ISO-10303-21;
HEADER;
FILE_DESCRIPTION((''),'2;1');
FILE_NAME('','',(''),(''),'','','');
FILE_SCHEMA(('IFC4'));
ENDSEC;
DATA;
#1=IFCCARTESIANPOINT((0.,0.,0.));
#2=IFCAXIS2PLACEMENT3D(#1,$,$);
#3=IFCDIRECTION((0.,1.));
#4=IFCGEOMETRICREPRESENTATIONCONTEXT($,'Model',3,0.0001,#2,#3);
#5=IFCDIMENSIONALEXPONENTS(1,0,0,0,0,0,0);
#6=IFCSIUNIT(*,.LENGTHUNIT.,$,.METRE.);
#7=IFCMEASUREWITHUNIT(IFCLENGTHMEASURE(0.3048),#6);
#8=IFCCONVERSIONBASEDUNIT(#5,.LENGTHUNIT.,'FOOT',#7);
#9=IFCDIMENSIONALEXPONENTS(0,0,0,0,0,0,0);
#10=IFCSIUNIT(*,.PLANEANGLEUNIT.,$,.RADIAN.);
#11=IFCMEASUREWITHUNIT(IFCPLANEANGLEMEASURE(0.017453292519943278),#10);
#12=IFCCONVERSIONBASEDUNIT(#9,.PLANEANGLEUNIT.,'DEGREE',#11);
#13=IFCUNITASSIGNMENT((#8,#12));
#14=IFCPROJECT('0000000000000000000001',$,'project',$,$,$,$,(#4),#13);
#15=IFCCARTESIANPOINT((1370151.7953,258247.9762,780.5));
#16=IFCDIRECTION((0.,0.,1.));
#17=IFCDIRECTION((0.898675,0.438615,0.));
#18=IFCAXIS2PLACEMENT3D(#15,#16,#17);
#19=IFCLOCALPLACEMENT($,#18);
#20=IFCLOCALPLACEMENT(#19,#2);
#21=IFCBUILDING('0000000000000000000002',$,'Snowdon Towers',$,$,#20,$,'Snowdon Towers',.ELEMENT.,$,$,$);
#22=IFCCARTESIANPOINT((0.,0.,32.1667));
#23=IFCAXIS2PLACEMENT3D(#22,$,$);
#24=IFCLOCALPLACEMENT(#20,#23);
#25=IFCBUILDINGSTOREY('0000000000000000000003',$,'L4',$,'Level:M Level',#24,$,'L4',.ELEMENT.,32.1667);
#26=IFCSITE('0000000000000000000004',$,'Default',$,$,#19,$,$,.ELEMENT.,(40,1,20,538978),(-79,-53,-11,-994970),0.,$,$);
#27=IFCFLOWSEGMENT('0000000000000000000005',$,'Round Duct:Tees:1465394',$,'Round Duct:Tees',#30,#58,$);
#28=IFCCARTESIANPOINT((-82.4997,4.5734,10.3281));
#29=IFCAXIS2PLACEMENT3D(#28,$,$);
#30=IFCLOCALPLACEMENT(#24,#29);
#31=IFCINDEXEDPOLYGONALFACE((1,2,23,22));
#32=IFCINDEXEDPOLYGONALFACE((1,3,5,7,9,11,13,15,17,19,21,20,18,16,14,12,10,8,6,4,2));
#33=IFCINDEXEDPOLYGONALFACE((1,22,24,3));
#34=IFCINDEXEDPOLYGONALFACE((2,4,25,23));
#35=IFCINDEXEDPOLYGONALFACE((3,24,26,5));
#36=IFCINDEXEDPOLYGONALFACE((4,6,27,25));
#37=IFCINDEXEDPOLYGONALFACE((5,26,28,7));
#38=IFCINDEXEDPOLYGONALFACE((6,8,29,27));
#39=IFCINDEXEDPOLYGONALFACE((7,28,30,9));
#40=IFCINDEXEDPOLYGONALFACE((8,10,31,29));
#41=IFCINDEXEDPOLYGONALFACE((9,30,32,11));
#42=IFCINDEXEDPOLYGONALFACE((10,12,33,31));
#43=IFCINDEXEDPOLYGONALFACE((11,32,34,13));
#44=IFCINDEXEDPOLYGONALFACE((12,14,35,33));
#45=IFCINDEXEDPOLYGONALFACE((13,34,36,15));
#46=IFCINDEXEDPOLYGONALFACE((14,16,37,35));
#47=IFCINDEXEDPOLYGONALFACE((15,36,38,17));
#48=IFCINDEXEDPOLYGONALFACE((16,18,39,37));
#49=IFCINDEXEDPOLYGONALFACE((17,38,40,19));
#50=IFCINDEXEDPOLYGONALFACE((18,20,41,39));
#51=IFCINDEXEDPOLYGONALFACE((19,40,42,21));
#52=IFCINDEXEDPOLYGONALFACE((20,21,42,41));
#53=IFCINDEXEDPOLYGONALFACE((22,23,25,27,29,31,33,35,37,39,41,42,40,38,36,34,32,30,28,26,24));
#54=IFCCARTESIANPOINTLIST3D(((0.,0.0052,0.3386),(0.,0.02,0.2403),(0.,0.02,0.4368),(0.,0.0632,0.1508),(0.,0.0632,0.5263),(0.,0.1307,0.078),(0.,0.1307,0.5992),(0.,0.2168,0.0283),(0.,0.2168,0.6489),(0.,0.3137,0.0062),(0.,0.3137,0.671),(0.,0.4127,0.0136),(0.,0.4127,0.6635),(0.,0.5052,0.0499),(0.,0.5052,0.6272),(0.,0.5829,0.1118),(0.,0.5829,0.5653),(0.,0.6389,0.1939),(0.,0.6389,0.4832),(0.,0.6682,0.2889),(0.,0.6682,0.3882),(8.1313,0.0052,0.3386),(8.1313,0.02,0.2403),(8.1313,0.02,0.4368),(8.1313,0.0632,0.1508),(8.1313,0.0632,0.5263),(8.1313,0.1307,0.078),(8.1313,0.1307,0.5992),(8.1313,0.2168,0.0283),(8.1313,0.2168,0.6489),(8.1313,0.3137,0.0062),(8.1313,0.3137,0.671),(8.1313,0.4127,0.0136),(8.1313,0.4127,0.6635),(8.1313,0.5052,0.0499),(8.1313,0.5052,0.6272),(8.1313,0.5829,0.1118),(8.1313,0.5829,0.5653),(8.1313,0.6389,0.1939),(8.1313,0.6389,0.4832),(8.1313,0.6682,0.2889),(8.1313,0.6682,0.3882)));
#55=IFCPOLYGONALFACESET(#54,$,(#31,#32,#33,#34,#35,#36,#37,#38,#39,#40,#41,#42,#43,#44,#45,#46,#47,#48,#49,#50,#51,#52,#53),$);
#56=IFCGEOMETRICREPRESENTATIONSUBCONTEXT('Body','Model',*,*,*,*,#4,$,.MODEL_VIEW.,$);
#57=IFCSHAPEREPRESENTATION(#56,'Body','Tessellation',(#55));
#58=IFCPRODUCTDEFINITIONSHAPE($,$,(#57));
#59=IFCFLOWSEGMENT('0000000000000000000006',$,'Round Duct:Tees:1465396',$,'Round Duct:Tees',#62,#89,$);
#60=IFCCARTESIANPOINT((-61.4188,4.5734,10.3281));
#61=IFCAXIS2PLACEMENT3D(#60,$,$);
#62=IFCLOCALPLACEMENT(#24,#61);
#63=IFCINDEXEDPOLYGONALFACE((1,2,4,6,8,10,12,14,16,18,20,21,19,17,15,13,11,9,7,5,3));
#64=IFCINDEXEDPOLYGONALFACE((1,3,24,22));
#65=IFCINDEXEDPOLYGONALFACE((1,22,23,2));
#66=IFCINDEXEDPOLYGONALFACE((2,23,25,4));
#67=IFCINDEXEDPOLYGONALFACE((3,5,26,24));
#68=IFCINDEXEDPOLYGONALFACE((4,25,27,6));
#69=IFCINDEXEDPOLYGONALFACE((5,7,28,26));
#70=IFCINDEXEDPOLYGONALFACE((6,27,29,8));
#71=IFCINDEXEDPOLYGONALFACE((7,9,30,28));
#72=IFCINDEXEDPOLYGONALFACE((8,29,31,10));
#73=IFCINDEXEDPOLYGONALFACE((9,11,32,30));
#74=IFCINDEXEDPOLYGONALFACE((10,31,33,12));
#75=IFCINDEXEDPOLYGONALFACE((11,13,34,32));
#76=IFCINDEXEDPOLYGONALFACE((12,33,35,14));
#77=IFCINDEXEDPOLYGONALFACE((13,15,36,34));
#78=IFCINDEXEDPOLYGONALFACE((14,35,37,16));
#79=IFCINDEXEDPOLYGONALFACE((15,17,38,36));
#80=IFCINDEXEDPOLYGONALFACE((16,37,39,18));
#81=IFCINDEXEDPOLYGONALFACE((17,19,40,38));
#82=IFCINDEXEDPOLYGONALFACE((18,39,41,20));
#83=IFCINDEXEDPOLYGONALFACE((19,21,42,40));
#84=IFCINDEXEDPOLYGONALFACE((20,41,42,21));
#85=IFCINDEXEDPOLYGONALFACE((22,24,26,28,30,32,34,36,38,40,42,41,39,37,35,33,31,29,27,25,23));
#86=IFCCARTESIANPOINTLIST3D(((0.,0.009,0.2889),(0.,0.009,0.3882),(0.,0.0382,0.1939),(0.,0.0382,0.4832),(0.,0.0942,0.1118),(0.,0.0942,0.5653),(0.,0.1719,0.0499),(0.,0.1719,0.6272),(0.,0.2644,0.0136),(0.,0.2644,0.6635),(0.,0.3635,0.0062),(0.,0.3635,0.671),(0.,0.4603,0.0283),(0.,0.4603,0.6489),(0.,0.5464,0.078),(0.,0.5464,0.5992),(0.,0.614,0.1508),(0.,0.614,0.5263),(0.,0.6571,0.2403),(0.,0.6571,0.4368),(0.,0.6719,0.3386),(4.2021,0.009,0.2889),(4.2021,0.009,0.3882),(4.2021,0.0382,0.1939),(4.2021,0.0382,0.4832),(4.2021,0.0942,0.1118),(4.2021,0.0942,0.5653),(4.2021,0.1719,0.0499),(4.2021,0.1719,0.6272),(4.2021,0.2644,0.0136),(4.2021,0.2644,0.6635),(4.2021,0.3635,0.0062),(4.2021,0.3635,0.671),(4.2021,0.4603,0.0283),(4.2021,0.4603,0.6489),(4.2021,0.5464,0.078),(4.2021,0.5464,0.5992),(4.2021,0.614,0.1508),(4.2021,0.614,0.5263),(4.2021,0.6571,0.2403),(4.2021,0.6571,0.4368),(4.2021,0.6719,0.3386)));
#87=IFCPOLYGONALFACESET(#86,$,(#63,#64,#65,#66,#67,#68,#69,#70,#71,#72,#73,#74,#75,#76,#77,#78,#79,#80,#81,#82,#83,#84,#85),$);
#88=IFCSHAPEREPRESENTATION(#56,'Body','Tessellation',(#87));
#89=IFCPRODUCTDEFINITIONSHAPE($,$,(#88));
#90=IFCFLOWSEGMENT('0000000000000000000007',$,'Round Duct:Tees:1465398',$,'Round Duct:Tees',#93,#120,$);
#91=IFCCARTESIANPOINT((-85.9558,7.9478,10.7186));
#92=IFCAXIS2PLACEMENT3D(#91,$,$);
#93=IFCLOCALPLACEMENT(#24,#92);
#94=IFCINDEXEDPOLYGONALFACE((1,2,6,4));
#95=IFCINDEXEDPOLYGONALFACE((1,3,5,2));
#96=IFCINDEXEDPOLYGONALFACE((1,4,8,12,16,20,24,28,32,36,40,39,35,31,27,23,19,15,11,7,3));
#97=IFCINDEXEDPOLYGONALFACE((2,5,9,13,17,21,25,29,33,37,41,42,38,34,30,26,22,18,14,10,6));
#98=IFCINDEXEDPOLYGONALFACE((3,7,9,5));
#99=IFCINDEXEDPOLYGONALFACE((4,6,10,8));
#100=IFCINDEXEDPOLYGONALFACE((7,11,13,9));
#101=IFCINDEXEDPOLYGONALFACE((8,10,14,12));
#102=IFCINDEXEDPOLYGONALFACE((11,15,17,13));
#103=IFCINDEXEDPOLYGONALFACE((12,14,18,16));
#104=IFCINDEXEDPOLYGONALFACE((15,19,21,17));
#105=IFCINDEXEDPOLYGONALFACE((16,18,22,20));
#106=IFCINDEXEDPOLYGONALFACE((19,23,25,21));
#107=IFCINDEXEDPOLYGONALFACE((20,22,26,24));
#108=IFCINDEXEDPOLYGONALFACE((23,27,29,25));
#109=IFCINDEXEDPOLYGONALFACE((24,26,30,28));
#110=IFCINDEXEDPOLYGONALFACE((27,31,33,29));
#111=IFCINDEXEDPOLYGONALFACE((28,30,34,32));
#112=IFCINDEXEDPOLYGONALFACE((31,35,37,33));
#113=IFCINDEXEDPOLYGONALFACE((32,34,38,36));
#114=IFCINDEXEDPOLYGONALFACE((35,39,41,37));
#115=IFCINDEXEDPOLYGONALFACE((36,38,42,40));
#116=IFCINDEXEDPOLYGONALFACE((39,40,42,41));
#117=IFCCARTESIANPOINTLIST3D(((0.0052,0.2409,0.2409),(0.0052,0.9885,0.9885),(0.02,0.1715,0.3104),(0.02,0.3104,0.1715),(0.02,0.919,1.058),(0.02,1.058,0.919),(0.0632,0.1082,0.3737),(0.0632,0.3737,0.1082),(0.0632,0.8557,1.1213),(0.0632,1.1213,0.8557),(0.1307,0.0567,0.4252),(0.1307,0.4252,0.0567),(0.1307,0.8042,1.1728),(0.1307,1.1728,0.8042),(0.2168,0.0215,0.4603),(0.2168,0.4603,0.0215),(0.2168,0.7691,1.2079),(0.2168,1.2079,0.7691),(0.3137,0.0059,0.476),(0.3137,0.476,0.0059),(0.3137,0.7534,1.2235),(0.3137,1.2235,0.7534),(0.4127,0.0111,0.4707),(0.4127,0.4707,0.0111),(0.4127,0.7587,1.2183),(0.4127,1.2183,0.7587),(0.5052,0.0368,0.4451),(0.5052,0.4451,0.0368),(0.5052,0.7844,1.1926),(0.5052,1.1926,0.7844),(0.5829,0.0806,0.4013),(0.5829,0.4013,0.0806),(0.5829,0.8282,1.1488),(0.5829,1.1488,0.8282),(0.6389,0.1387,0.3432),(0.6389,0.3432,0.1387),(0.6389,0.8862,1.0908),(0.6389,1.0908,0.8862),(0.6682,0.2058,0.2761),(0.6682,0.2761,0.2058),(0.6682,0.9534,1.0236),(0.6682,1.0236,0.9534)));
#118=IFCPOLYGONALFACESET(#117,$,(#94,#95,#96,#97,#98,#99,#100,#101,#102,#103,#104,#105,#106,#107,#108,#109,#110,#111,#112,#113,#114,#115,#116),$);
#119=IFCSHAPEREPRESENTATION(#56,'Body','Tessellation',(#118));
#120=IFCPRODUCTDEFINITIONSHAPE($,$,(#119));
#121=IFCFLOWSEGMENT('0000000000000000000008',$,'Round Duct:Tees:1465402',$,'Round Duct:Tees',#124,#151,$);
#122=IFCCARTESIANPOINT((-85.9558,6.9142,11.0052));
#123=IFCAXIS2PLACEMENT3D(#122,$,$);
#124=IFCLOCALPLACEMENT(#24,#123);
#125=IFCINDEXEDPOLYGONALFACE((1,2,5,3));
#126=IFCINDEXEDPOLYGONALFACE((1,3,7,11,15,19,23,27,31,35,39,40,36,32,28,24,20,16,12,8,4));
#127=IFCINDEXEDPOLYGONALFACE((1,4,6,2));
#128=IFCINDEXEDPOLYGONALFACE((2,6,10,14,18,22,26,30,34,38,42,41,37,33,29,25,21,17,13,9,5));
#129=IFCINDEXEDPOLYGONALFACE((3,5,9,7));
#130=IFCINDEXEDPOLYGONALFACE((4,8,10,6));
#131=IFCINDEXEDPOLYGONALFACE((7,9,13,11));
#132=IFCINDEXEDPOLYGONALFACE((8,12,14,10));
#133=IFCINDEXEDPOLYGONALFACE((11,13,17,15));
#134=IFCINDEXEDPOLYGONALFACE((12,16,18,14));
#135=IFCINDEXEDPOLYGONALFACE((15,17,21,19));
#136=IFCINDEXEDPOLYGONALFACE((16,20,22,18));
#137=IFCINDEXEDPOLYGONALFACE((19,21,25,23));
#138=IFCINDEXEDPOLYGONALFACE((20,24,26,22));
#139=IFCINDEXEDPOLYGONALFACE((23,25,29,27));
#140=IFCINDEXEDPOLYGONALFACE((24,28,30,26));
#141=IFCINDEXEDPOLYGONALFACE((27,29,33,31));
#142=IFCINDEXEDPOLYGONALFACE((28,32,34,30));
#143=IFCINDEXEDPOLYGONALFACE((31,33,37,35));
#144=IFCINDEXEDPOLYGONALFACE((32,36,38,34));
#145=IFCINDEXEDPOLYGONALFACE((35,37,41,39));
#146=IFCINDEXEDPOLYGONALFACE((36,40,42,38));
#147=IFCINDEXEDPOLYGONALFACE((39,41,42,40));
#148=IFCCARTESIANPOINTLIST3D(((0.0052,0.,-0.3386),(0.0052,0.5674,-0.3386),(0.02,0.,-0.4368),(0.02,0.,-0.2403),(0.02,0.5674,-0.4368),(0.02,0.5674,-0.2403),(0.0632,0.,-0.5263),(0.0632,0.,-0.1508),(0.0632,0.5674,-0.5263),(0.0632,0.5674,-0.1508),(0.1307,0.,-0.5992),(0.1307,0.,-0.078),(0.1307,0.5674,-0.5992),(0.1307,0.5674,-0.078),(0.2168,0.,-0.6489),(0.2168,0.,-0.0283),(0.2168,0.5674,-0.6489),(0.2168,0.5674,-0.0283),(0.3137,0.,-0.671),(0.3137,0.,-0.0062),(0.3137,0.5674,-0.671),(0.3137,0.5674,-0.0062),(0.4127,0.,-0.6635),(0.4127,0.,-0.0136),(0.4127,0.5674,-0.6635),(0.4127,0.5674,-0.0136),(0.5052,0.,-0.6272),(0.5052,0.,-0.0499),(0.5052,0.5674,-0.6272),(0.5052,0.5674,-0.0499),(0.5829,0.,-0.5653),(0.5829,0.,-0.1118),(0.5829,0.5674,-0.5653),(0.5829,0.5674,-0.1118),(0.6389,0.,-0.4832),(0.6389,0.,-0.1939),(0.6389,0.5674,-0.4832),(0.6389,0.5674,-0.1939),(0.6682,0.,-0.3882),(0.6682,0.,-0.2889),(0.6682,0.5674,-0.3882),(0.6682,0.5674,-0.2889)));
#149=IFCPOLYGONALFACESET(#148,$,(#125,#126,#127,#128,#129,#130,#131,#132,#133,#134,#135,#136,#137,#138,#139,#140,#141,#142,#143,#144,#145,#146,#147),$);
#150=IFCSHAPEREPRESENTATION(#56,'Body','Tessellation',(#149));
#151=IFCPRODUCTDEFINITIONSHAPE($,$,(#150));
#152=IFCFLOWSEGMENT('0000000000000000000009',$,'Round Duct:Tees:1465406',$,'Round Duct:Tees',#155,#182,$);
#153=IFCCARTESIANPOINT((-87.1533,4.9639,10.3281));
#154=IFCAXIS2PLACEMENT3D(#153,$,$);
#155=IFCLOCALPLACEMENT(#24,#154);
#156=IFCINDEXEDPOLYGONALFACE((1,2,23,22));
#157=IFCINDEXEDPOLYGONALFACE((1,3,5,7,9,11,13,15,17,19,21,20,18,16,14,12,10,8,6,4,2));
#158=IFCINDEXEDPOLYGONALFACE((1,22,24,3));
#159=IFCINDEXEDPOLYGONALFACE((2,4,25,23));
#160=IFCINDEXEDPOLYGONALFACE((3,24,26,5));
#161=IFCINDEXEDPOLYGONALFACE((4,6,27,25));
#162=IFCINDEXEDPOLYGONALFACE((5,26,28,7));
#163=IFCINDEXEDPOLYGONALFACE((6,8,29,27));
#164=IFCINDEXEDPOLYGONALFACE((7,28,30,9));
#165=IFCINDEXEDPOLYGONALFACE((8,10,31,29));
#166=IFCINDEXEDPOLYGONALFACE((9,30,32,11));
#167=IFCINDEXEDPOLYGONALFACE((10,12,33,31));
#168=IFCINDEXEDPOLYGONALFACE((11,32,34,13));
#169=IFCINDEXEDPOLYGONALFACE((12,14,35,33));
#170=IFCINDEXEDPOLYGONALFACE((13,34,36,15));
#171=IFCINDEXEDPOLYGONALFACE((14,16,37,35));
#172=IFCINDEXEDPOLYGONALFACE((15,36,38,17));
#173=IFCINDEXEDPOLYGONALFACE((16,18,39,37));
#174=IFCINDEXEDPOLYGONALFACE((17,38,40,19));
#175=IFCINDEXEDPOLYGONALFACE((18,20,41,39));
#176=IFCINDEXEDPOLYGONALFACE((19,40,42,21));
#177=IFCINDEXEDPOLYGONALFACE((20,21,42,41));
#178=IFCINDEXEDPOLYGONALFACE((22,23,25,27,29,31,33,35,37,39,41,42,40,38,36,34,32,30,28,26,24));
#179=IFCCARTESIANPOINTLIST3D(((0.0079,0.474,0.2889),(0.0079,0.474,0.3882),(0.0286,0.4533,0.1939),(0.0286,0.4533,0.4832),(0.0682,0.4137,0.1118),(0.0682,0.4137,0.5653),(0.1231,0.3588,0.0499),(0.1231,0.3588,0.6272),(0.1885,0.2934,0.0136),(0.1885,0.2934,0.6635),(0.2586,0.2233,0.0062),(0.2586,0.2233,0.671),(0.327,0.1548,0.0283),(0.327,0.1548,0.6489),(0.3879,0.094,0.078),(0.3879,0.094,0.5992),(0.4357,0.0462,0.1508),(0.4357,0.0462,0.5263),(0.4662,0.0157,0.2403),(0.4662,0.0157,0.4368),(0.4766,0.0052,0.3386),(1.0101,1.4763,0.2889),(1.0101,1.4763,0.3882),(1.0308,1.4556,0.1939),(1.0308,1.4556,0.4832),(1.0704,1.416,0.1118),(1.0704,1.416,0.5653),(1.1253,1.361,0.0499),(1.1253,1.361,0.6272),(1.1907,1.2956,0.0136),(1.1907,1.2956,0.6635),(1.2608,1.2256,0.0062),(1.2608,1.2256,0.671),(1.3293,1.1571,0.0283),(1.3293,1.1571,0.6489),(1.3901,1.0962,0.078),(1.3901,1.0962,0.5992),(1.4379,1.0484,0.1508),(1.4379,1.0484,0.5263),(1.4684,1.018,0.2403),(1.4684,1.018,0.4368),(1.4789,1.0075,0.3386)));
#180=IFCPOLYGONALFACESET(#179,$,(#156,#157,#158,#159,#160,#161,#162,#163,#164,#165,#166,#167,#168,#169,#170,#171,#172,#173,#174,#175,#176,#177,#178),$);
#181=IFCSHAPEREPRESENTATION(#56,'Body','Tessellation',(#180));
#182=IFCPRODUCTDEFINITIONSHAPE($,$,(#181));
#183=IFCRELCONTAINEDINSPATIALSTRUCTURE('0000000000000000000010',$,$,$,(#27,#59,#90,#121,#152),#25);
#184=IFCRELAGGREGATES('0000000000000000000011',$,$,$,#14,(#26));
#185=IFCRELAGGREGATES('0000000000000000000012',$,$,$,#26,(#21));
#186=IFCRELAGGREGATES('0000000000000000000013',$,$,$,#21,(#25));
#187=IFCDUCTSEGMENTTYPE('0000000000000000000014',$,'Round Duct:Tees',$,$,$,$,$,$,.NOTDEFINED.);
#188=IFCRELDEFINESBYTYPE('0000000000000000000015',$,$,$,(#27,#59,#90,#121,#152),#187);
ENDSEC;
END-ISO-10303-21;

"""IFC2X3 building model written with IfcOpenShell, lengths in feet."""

from ifc_helpers import new_model, entity, si_unit, converted_unit, direction, frame, frame_2d, origin, origin_2d_with_axis, place, context, subcontext, project, spatial, circle, extrude, type_object, element, save


model = new_model("IFC2X3")

# Units and contexts
model_context = context("Model", 3, precision=0.0001, world=origin(), true_north=direction((0.0, 1.0)))
body_context = subcontext(model_context, "Body", "Model", "MODEL_VIEW")
ifc_project = project(units=[converted_unit("LENGTHUNIT", "FOOT", entity("IfcLengthMeasure", 0.3048), si_unit("LENGTHUNIT", "METRE"), dimensions=[1, 0, 0, 0, 0, 0, 0]), converted_unit("PLANEANGLEUNIT", "DEGREE", entity("IfcPlaneAngleMeasure", 0.017453292519943278), si_unit("PLANEANGLEUNIT", "RADIAN"), dimensions=[0, 0, 0, 0, 0, 0, 0])], contexts=[model_context])

# Site, building, storey
site_placement = place(None, frame((1370151.7953, 258247.9762, 780.5), z_axis=(0.0, 0.0, 1.0), x_axis=(0.898675, 0.438615, 0.0)))
site = spatial("IfcSite", under=ifc_project, at=site_placement, Name="Default", CompositionType="ELEMENT", RefLatitude=(40, 1, 20, 538978), RefLongitude=(-79, -53, -11, -994970), RefElevation=0.0)
building_placement = place(site_placement, origin())
building = spatial("IfcBuilding", under=site, at=building_placement, Name="Snowdon Towers", LongName="Snowdon Towers", CompositionType="ELEMENT")
storey_placement = place(building_placement, frame((0.0, 0.0, 32.1667)))
storey = spatial("IfcBuildingStorey", under=building, at=storey_placement, Name="L4", ObjectType="Level:M Level", LongName="L4", CompositionType="ELEMENT", Elevation=32.1667)

# Flow segments
duct_segment_type = type_object("IfcDuctSegmentType", Name="Round Duct:Tees", PredefinedType="NOTDEFINED")
flow_segment_1_placement = place(storey_placement, frame((-82.4997, 4.5734, 10.3281)))
element("IfcFlowSegment", 1, at=flow_segment_1_placement, inside=storey, type_object=duct_segment_type, Name="Round Duct:Tees:1465394", ObjectType="Round Duct:Tees", context=body_context, shape_type="SweptSolid", body=[
    extrude(circle(Radius=0.3333, at=frame_2d((0.0, 0.0), x_axis=(1.0, 0.0))), frame((0.0, 0.3386, 0.3386), z_axis=(1.0, 0.0, 0.0), x_axis=(0.0, -1.0, 0.0)), (0.0, 0.0, 1.0), 8.1313),
])
flow_segment_2_placement = place(storey_placement, frame((-61.4188, 4.5734, 10.3281)))
element("IfcFlowSegment", 2, at=flow_segment_2_placement, inside=storey, type_object=duct_segment_type, Name="Round Duct:Tees:1465396", ObjectType="Round Duct:Tees", context=body_context, shape_type="SweptSolid", body=[
    extrude(circle(Radius=0.3333, at=frame_2d((0.0, 0.0), x_axis=(1.0, 0.0))), frame((0.0, 0.3386, 0.3386), z_axis=(1.0, 0.0, 0.0), x_axis=(0.0, 1.0, 0.0)), (0.0, 0.0, 1.0), 4.2021),
])
flow_segment_3_placement = place(storey_placement, frame((-85.9558, 7.9478, 10.7186)))
element("IfcFlowSegment", 3, at=flow_segment_3_placement, inside=storey, type_object=duct_segment_type, Name="Round Duct:Tees:1465398", ObjectType="Round Duct:Tees", context=body_context, shape_type="SweptSolid", body=[
    extrude(circle(Radius=0.3333, at=origin_2d_with_axis()), frame((0.3386, 0.2409, 0.2409), z_axis=(0.0, 0.707107, 0.707107), x_axis=(-1.0, 0.0, 0.0)), (0.0, 0.0, 1.0), 1.0572),
])
flow_segment_4_placement = place(storey_placement, frame((-85.9558, 6.9142, 11.0052)))
element("IfcFlowSegment", 4, at=flow_segment_4_placement, inside=storey, type_object=duct_segment_type, Name="Round Duct:Tees:1465402", ObjectType="Round Duct:Tees", context=body_context, shape_type="SweptSolid", body=[
    extrude(circle(Radius=0.3333, at=frame_2d((0.0, 0.0), x_axis=(1.0, 0.0))), frame((0.3386, 0.0, -0.3386), z_axis=(0.0, 1.0, 0.0), x_axis=(-1.0, 0.0, 0.0)), (0.0, 0.0, 1.0), 0.5674),
])
flow_segment_5_placement = place(storey_placement, frame((-87.1533, 4.9639, 10.3281)))
element("IfcFlowSegment", 5, at=flow_segment_5_placement, inside=storey, type_object=duct_segment_type, Name="Round Duct:Tees:1465406", ObjectType="Round Duct:Tees", context=body_context, shape_type="SweptSolid", body=[
    extrude(circle(Radius=0.3333, at=frame_2d((0.0, 0.0), x_axis=(1.0, 0.0))), frame((0.2409, 0.2409, 0.3386), z_axis=(0.707107, 0.707107, 0.0), x_axis=(0.707107, -0.707107, 0.0)), (0.0, 0.0, 1.0), 1.4174),
])

save(model, "model.ifc")
